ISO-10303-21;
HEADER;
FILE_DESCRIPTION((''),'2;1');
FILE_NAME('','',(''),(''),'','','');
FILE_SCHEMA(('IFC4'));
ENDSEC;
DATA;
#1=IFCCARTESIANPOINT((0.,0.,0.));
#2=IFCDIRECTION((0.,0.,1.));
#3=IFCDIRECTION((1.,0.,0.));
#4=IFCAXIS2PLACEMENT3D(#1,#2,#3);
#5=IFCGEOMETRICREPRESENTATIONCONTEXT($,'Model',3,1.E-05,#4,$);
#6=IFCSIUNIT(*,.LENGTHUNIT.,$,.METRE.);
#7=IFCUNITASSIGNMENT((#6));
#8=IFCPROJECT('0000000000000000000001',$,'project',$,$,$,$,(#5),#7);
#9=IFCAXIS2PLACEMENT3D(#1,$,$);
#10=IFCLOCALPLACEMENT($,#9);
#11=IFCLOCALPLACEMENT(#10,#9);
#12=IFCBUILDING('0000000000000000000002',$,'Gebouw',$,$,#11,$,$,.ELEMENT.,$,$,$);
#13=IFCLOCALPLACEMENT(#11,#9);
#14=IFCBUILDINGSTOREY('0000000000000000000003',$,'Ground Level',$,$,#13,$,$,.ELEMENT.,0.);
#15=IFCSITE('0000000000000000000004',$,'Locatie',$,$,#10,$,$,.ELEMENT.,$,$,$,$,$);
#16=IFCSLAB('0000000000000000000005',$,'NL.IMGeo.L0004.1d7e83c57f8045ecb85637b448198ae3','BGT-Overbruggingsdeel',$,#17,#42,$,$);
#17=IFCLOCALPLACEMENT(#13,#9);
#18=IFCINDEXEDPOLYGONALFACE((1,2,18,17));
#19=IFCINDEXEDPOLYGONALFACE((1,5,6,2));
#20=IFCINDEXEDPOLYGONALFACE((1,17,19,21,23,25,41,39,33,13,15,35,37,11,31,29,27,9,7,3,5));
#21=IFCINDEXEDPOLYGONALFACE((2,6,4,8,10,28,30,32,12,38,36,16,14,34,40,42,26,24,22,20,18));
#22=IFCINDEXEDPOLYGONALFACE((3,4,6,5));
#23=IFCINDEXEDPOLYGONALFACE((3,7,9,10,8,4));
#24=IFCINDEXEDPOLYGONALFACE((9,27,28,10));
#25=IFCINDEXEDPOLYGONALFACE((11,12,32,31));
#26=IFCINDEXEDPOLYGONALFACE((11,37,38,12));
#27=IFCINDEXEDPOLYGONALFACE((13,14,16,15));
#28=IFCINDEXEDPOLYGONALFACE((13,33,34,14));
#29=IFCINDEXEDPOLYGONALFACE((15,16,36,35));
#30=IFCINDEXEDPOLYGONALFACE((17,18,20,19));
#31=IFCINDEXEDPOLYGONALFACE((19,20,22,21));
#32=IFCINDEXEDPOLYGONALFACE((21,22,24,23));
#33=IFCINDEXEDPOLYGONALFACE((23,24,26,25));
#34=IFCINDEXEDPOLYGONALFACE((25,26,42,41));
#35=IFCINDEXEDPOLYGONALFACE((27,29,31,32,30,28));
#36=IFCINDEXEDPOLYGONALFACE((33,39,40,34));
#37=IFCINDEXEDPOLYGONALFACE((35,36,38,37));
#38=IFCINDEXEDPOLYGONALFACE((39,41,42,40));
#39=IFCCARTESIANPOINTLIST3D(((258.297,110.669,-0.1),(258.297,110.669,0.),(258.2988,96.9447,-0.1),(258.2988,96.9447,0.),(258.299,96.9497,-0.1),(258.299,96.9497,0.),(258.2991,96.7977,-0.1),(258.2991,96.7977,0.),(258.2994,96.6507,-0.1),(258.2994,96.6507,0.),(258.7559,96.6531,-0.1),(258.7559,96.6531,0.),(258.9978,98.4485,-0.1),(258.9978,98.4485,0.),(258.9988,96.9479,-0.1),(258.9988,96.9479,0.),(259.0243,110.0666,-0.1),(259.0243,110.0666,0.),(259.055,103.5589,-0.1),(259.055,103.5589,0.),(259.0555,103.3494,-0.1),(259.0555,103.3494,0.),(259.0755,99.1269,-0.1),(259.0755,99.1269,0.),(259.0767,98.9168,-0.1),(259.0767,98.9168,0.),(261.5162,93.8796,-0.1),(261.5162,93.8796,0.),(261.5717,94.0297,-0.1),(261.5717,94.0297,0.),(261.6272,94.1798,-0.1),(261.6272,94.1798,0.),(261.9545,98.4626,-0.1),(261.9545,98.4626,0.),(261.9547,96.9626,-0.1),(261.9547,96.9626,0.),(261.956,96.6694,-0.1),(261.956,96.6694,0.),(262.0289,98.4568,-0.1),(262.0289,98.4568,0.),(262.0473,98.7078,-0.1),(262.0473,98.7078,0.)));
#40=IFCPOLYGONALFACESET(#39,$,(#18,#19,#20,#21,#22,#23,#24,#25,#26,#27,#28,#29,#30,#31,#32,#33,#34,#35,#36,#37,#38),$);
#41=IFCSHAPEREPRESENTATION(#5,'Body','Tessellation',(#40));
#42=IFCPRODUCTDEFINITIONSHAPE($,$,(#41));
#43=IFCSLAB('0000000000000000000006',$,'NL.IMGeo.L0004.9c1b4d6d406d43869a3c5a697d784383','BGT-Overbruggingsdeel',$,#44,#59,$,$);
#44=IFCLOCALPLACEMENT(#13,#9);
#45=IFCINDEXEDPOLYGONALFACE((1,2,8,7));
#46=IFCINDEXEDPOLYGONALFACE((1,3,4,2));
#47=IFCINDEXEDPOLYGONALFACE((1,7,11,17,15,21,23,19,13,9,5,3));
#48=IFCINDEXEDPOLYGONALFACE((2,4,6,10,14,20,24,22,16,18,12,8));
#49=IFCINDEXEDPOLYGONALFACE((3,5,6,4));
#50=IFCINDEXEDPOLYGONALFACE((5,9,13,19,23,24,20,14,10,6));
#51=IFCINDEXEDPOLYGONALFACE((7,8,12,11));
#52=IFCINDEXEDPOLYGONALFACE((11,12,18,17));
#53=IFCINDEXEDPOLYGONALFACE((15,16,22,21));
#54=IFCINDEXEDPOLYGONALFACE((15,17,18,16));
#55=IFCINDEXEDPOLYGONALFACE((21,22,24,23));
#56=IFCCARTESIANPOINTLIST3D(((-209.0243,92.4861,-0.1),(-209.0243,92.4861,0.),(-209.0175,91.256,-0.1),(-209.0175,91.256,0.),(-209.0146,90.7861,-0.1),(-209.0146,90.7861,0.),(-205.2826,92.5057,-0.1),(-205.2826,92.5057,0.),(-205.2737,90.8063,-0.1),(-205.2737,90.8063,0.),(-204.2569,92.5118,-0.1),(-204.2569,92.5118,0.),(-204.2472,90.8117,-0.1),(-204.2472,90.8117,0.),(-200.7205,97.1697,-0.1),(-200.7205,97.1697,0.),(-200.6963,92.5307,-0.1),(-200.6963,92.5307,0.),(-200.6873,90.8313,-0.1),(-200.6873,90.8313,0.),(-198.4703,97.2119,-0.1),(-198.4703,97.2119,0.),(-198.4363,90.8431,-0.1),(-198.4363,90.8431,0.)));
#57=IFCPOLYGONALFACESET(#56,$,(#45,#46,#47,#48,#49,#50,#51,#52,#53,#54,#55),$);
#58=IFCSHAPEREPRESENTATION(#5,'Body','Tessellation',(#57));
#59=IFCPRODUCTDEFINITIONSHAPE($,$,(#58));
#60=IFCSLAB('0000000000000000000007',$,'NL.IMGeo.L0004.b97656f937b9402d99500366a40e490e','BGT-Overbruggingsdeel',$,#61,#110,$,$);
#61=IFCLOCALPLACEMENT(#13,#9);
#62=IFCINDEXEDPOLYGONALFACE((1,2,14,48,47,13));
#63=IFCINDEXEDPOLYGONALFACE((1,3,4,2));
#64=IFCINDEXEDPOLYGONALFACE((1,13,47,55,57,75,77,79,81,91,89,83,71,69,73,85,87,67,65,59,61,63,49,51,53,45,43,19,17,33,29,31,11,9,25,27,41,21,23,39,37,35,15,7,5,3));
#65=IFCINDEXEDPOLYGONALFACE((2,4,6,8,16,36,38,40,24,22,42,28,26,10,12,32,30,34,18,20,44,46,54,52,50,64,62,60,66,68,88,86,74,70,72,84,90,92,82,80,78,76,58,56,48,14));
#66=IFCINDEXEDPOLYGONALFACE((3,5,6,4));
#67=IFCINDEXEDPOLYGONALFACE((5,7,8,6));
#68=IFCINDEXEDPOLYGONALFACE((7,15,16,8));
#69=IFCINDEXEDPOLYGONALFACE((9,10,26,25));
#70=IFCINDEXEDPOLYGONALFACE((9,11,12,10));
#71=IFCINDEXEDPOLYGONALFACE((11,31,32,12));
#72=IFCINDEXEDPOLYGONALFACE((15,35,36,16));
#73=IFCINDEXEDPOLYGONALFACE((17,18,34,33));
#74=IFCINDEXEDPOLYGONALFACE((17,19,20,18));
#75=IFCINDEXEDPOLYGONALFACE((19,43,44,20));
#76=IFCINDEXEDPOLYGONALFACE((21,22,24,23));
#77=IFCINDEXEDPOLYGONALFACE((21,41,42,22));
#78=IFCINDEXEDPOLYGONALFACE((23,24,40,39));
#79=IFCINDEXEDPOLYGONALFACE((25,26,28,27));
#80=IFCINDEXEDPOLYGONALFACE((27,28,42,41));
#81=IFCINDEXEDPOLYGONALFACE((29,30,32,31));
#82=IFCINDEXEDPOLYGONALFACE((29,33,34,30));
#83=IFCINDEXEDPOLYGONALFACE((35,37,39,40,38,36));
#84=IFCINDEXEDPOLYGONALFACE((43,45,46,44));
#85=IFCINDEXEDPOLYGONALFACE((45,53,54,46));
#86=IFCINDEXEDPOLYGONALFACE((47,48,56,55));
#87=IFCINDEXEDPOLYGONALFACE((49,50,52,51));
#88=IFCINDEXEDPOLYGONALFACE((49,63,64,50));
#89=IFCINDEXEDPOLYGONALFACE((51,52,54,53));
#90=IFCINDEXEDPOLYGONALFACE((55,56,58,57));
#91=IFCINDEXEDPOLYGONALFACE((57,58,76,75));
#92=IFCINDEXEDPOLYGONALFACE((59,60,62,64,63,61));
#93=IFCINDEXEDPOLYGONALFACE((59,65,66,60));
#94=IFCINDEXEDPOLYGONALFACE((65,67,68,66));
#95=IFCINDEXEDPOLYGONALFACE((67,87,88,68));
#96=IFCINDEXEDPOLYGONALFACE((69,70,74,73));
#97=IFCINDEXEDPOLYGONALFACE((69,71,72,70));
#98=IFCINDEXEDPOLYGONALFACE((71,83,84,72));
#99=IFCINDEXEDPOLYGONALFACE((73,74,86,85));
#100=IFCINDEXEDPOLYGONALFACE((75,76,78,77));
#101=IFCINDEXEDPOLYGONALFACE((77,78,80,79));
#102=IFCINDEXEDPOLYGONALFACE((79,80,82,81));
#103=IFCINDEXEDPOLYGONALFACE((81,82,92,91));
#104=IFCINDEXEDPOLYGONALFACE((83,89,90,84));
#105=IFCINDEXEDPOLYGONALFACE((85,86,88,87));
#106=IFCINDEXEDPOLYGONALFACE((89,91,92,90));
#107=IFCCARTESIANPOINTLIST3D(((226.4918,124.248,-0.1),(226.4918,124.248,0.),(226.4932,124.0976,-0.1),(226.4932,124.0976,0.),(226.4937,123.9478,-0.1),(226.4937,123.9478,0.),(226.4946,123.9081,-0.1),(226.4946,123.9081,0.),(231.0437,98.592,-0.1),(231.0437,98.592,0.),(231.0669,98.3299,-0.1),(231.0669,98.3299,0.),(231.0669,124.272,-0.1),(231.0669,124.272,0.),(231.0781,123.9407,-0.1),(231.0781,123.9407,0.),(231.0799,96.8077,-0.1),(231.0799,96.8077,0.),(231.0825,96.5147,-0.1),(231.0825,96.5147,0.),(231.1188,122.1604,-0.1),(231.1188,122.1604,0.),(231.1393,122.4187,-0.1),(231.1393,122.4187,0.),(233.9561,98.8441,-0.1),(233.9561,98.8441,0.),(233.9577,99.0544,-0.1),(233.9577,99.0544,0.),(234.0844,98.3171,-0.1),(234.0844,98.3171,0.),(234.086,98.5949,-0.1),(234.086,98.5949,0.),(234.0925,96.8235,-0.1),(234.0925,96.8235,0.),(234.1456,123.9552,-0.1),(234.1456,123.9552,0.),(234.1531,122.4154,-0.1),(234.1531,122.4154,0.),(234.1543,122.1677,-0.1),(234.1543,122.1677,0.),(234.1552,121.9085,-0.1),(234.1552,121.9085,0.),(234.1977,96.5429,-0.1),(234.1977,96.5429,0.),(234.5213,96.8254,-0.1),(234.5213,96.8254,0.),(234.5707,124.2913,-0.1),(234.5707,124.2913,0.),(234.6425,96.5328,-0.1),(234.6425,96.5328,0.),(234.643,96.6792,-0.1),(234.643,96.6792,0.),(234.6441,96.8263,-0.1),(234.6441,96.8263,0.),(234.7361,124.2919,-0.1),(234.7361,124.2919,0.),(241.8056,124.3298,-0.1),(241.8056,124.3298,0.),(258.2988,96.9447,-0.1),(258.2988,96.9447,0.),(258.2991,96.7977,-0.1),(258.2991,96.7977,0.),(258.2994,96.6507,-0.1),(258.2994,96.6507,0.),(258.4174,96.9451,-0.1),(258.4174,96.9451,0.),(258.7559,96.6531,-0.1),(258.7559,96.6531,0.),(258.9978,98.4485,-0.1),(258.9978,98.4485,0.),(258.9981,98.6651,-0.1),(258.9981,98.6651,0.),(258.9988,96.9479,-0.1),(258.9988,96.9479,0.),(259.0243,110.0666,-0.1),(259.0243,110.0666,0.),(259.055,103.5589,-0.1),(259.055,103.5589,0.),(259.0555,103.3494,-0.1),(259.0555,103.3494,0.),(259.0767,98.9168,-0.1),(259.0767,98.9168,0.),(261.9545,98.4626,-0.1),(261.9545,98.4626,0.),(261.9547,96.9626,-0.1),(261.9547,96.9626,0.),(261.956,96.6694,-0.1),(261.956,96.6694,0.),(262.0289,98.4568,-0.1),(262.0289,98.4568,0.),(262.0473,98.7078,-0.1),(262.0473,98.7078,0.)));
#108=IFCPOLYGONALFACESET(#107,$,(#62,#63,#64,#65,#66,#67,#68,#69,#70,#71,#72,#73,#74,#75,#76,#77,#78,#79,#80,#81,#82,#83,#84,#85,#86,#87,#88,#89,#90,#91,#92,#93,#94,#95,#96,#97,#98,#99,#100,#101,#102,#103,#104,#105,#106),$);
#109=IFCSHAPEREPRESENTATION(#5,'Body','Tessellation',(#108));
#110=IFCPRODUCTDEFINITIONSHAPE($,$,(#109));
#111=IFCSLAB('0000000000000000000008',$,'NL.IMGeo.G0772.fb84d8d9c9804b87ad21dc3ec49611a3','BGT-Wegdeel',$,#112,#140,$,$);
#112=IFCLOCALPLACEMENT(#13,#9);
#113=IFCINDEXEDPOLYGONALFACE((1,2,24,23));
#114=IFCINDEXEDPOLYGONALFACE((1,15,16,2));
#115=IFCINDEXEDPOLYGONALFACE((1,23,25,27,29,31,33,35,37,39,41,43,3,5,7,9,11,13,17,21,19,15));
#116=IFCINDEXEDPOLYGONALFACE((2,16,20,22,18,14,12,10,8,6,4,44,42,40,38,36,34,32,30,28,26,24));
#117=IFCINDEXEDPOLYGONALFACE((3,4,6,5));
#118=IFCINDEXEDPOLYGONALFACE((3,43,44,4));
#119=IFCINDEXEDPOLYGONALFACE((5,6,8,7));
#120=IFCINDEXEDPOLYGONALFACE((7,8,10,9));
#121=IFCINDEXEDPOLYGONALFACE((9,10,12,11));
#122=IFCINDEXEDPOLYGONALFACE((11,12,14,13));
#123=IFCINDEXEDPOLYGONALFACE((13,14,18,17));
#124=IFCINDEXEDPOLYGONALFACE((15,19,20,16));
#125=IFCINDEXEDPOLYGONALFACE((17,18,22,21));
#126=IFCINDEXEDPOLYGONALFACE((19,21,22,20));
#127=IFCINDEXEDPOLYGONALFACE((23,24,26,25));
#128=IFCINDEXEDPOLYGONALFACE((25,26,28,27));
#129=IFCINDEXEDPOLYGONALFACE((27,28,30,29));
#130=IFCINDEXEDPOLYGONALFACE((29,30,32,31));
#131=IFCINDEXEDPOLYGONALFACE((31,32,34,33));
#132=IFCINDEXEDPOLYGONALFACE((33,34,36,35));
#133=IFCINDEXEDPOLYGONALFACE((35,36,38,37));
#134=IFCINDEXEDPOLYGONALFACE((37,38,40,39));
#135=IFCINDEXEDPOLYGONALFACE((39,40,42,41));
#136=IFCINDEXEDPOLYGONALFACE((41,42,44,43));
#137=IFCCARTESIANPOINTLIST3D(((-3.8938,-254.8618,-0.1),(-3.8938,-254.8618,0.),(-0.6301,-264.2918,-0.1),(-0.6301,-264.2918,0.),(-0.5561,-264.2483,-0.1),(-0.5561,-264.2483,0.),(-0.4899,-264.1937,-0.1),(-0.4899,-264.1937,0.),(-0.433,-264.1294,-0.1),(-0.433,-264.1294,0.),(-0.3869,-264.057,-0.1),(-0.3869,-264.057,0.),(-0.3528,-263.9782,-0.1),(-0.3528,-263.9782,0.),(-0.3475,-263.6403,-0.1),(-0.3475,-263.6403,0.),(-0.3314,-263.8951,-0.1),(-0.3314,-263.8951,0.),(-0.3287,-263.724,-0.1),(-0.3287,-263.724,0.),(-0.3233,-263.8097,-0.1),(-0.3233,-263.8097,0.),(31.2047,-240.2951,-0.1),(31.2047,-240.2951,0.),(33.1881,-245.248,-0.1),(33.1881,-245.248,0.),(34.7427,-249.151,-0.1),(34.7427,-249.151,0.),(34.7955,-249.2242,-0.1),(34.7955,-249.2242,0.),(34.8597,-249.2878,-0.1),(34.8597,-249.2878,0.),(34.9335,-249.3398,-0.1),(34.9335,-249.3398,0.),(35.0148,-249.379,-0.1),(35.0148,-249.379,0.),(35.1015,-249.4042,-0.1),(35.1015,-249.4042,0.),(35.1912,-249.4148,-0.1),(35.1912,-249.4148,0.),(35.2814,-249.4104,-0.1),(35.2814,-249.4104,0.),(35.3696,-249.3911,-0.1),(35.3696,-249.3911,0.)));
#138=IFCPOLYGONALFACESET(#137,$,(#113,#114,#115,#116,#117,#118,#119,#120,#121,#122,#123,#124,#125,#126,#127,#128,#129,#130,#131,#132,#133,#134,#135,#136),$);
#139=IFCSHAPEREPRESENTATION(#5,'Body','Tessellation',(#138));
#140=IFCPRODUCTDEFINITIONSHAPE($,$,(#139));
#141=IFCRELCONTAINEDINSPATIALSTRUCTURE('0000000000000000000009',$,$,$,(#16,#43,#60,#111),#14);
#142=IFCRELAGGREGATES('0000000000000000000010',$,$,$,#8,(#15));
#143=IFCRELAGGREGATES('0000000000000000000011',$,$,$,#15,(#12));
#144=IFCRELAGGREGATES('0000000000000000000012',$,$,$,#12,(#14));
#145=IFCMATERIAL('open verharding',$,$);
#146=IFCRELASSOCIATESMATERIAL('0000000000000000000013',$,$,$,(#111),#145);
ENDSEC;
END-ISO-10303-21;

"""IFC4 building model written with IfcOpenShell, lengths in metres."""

from ifc_helpers import new_model, si_unit, frame, origin, origin_with_axes, place, context, project, spatial, polyline, outline, extrude, material, element, save


model = new_model("IFC4")

# Units and contexts
model_context = context("Model", 3, precision=1e-05, world=origin_with_axes())
ifc_project = project(units=[si_unit("LENGTHUNIT", "METRE")], contexts=[model_context])

# Site, building, storey
site_placement = place(None, origin())
site = spatial("IfcSite", under=ifc_project, at=site_placement, Name="Locatie", CompositionType="ELEMENT")
building_placement = place(site_placement, origin())
building = spatial("IfcBuilding", under=site, at=building_placement, Name="Gebouw", CompositionType="ELEMENT")
storey_placement = place(building_placement, origin())
storey = spatial("IfcBuildingStorey", under=building, at=storey_placement, Name="Ground Level", CompositionType="ELEMENT", Elevation=0.0)

# Slabs
slab_1_placement = place(storey_placement, origin())
element("IfcSlab", 1, at=slab_1_placement, inside=storey, Name="NL.IMGeo.L0004.1d7e83c57f8045ecb85637b448198ae3", Description="BGT-Overbruggingsdeel", context=model_context, shape_type="SweptSolid", body=[
    extrude(outline(polyline([(259.055, 103.5589), (259.0555, 103.3494), (259.0755, 99.1269), (259.0767, 98.9168), (262.0473, 98.7078), (262.0289, 98.4568), (261.9545, 98.4626), (258.9978, 98.4485), (258.9988, 96.9479), (261.9547, 96.9626), (261.956, 96.6694), (258.7559, 96.6531), (261.6272, 94.1798), (261.5717, 94.0297), (261.5162, 93.8796), (258.2994, 96.6507), (258.2991, 96.7977), (258.2988, 96.9447), (258.299, 96.9497), (258.297, 110.669), (259.0243, 110.0666), (259.055, 103.5589)])), frame((0.0, 0.0, -0.1), z_axis=(0.0, 0.0, 1.0), x_axis=(1.0, 0.0, 0.0)), (0.0, 0.0, 1.0), 0.1),
])
slab_2_placement = place(storey_placement, origin())
element("IfcSlab", 2, at=slab_2_placement, inside=storey, Name="NL.IMGeo.L0004.9c1b4d6d406d43869a3c5a697d784383", Description="BGT-Overbruggingsdeel", context=model_context, shape_type="SweptSolid", body=[
    extrude(outline(polyline([(-209.0175, 91.256), (-209.0243, 92.4861), (-205.2826, 92.5057), (-204.2569, 92.5118), (-200.6963, 92.5307), (-200.7205, 97.1697), (-198.4703, 97.2119), (-198.4363, 90.8431), (-200.6873, 90.8313), (-204.2472, 90.8117), (-205.2737, 90.8063), (-209.0146, 90.7861), (-209.0175, 91.256)])), frame((0.0, 0.0, -0.1), z_axis=(0.0, 0.0, 1.0), x_axis=(1.0, 0.0, 0.0)), (0.0, 0.0, 1.0), 0.1),
])
slab_3_placement = place(storey_placement, origin())
element("IfcSlab", 3, at=slab_3_placement, inside=storey, Name="NL.IMGeo.L0004.b97656f937b9402d99500366a40e490e", Description="BGT-Overbruggingsdeel", context=model_context, shape_type="SweptSolid", body=[
    extrude(outline(polyline([(259.055, 103.5589), (259.0555, 103.3494), (259.0767, 98.9168), (262.0473, 98.7078), (262.0289, 98.4568), (261.9545, 98.4626), (258.9981, 98.6651), (258.9978, 98.4485), (258.9988, 96.9479), (261.9547, 96.9626), (261.956, 96.6694), (258.7559, 96.6531), (258.4174, 96.9451), (258.2988, 96.9447), (258.2991, 96.7977), (258.2994, 96.6507), (234.6425, 96.5328), (234.643, 96.6792), (234.6441, 96.8263), (234.5213, 96.8254), (234.1977, 96.5429), (231.0825, 96.5147), (231.0799, 96.8077), (234.0925, 96.8235), (234.0844, 98.3171), (234.086, 98.5949), (231.0669, 98.3299), (231.0437, 98.592), (233.9561, 98.8441), (233.9577, 99.0544), (234.1552, 121.9085), (231.1188, 122.1604), (231.1393, 122.4187), (234.1543, 122.1677), (234.1531, 122.4154), (234.1456, 123.9552), (231.0781, 123.9407), (226.4946, 123.9081), (226.4937, 123.9478), (226.4932, 124.0976), (226.4918, 124.248), (231.0669, 124.272), (234.5707, 124.2913), (234.7361, 124.2919), (241.8056, 124.3298), (259.0243, 110.0666), (259.055, 103.5589)])), frame((0.0, 0.0, -0.1), z_axis=(0.0, 0.0, 1.0), x_axis=(1.0, 0.0, 0.0)), (0.0, 0.0, 1.0), 0.1),
])
ifc_material = material(Name="open verharding")
slab_4_placement = place(storey_placement, origin())
element("IfcSlab", 4, at=slab_4_placement, inside=storey, material=ifc_material, Name="NL.IMGeo.G0772.fb84d8d9c9804b87ad21dc3ec49611a3", Description="BGT-Wegdeel", context=model_context, shape_type="SweptSolid", body=[
    extrude(outline(polyline([(-3.8938, -254.8618), (31.2047, -240.2951), (33.1881, -245.248), (34.7427, -249.151), (34.7955, -249.2242), (34.8597, -249.2878), (34.9335, -249.3398), (35.0148, -249.379), (35.1015, -249.4042), (35.1912, -249.4148), (35.2814, -249.4104), (35.3696, -249.3911), (-0.6301, -264.2918), (-0.5561, -264.2483), (-0.4899, -264.1937), (-0.433, -264.1294), (-0.3869, -264.057), (-0.3528, -263.9782), (-0.3314, -263.8951), (-0.3233, -263.8097), (-0.3287, -263.724), (-0.3475, -263.6403), (-3.8938, -254.8618)])), frame((0.0, 0.0, -0.1), z_axis=(0.0, 0.0, 1.0), x_axis=(1.0, 0.0, 0.0)), (0.0, 0.0, 1.0), 0.1),
])

save(model, "model.ifc")
